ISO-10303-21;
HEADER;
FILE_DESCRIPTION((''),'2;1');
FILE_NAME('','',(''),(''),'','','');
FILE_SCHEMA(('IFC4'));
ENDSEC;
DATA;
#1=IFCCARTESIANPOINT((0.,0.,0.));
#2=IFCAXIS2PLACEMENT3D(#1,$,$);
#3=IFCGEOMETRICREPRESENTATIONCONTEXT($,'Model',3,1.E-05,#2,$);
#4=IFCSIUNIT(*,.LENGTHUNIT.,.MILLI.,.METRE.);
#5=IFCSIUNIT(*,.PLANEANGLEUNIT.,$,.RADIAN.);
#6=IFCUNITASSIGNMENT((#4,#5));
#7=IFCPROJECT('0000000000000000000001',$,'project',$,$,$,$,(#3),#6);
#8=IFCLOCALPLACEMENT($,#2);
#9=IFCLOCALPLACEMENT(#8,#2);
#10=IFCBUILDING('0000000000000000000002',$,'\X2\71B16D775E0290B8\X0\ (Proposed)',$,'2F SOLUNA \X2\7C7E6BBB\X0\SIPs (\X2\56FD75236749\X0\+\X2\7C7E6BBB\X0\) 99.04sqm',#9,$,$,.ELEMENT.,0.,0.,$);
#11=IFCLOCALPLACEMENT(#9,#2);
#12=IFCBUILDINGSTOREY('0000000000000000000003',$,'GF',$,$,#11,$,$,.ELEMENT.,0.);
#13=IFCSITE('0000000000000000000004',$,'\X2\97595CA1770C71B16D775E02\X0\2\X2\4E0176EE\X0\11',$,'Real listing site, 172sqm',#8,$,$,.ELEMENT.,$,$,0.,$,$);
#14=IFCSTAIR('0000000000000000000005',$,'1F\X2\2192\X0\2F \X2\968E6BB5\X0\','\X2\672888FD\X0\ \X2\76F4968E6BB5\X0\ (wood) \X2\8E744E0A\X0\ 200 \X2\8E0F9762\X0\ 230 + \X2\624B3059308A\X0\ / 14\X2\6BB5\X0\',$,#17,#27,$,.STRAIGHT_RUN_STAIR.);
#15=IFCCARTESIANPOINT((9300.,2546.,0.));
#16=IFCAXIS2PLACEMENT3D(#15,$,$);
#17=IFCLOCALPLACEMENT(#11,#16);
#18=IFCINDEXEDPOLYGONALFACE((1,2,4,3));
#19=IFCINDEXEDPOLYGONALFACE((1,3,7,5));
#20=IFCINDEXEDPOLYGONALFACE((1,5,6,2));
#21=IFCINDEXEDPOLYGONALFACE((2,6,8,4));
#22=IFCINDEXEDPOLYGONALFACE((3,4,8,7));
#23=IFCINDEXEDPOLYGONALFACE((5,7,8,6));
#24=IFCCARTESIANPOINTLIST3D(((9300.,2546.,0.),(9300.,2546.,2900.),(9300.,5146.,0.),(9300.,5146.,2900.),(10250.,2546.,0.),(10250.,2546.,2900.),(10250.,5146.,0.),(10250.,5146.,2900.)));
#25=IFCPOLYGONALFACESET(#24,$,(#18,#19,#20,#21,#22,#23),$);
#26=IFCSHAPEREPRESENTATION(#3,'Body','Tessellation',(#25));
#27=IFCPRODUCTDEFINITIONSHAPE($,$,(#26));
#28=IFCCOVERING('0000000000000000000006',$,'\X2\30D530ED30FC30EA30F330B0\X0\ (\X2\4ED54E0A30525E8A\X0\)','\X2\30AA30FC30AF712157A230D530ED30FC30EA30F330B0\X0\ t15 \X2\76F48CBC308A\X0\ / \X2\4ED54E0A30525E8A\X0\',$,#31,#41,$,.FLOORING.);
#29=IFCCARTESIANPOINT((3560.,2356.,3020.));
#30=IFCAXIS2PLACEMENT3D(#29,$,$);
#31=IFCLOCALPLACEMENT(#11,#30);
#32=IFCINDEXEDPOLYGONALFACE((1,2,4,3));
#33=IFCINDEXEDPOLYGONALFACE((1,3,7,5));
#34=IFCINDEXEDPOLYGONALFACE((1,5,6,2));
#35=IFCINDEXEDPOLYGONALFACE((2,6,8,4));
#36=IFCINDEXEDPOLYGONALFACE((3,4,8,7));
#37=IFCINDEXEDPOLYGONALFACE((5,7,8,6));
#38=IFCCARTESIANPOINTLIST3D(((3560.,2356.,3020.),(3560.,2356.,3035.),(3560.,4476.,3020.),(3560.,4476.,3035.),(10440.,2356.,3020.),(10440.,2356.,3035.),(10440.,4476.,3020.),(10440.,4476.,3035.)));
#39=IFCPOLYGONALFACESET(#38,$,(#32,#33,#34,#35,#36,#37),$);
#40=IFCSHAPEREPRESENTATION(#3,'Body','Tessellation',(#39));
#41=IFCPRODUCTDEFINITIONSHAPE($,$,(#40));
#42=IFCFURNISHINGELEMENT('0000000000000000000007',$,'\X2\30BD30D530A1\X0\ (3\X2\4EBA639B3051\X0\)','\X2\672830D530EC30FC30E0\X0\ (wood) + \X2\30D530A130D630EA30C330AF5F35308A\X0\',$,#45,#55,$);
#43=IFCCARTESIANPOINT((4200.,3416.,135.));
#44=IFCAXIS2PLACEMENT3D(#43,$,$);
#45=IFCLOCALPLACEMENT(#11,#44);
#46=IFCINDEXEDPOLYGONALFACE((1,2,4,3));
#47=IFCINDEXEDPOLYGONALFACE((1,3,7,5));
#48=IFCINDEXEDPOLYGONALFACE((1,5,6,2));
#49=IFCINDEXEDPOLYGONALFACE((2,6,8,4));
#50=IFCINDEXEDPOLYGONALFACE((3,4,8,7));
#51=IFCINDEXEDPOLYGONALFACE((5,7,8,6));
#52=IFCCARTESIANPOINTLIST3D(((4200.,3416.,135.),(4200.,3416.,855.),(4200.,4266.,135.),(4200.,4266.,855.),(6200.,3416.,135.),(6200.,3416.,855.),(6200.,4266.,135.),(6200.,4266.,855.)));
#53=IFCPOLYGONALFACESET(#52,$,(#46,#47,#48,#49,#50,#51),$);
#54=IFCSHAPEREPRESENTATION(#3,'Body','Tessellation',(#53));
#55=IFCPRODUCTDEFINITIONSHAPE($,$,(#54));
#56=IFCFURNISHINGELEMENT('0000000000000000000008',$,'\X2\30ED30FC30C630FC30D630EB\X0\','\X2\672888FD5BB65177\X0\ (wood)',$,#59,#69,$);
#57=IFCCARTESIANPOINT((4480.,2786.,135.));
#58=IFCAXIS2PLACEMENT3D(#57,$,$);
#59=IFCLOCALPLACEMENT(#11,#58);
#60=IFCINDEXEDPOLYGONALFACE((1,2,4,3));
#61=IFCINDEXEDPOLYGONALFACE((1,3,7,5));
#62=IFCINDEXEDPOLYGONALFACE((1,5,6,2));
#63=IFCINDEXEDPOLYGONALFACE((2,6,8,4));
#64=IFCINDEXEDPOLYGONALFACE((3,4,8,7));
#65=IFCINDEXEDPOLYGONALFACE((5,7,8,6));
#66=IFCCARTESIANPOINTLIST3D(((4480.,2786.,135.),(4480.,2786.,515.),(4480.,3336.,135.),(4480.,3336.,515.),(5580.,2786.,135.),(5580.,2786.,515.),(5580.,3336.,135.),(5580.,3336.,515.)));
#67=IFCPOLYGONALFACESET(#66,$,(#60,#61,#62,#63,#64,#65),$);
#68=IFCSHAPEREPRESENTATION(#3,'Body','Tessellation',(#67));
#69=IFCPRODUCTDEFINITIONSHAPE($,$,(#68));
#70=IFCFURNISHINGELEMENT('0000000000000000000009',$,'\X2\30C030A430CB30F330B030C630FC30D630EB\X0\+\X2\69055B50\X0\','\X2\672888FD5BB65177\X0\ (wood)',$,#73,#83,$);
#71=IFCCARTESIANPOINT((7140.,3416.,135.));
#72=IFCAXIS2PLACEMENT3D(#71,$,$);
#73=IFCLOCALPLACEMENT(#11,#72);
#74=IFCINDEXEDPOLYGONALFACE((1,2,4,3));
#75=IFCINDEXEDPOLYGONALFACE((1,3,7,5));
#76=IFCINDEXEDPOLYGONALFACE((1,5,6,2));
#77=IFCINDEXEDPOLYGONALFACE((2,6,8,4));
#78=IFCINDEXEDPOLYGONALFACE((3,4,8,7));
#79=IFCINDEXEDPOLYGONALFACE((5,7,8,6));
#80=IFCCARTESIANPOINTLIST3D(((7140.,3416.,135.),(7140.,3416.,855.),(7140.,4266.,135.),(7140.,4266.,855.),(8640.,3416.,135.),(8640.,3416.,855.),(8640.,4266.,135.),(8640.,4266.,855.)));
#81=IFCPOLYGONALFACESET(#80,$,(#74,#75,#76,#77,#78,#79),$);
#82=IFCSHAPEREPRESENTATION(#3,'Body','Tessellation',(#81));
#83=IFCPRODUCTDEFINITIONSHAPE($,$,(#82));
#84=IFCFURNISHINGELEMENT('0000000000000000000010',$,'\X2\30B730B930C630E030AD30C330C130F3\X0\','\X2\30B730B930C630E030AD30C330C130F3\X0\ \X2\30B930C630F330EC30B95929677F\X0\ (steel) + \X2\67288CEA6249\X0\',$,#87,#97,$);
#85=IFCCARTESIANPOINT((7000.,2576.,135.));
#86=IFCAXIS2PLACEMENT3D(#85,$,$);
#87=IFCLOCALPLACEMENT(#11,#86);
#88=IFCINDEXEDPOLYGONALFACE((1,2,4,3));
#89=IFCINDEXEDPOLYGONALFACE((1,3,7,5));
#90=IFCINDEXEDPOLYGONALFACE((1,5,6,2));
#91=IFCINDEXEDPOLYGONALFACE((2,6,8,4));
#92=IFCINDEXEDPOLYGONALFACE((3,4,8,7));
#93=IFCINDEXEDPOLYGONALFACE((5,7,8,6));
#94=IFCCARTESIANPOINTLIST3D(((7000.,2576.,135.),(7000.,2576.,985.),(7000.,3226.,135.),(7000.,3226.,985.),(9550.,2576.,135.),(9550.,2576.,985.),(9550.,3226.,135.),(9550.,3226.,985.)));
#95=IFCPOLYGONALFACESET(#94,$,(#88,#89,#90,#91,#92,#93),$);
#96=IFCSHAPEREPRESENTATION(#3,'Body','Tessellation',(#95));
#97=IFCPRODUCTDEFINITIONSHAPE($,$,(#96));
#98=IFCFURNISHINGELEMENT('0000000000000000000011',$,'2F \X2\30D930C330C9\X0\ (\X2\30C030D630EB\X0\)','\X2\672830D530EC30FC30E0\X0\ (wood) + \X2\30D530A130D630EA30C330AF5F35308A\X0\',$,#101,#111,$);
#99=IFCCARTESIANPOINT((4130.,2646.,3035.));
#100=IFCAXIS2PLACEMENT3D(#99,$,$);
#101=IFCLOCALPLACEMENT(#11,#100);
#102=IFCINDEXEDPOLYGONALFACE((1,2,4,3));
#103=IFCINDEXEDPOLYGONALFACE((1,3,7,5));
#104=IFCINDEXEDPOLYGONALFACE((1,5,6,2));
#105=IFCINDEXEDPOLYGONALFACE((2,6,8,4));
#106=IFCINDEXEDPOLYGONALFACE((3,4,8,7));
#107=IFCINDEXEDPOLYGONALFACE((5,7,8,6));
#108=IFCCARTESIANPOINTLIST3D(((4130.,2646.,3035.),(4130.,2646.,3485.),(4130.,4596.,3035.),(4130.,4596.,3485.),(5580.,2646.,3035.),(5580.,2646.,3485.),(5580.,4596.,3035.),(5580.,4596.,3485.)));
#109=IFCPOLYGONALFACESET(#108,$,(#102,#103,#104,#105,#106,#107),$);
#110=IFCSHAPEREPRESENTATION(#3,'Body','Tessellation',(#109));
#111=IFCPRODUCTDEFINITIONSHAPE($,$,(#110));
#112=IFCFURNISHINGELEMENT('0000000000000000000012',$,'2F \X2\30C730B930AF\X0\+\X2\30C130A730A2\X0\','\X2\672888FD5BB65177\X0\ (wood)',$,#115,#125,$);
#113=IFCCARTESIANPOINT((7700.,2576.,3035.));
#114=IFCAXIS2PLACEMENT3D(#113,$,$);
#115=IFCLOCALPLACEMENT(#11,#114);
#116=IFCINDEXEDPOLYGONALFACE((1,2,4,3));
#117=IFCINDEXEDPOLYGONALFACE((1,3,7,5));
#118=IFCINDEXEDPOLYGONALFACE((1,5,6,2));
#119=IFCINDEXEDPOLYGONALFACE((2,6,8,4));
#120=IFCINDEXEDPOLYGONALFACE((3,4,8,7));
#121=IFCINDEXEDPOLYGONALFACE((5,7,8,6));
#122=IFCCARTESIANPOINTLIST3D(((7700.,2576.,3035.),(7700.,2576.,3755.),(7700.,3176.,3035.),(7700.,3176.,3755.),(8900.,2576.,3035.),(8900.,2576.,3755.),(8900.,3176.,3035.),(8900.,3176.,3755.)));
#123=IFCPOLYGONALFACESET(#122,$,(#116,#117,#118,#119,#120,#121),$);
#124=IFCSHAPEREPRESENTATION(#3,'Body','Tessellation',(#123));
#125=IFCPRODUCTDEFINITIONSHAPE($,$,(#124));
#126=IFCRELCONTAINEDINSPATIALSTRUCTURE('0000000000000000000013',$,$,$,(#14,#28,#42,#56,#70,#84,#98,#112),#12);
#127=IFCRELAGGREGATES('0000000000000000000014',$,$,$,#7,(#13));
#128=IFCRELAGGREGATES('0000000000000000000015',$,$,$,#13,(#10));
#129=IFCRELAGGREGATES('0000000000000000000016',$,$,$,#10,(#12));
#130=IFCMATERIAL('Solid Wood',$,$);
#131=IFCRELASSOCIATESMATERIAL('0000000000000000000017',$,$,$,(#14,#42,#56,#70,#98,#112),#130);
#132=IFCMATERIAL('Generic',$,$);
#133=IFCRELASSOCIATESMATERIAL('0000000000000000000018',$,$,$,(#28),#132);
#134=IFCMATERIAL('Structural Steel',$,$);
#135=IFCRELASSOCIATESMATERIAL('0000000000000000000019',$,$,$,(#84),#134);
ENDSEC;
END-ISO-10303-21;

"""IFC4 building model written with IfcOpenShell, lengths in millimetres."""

from ifc_helpers import new_model, si_unit, frame, frame_2d, origin, place, context, project, spatial, rectangle, extrude, material, element, save


model = new_model("IFC4")

# Units and contexts
model_context = context("Model", 3, precision=1e-05, world=origin())
ifc_project = project(units=[si_unit("LENGTHUNIT", "METRE", prefix="MILLI"), si_unit("PLANEANGLEUNIT", "RADIAN")], contexts=[model_context])

# Site, building, storey
site_placement = place(None, origin())
site = spatial("IfcSite", under=ifc_project, at=site_placement, Name="静岡県熱海市2丁目11", ObjectType="Real listing site, 172sqm", CompositionType="ELEMENT", RefElevation=0.0)
building_placement = place(site_placement, origin())
building = spatial("IfcBuilding", under=site, at=building_placement, Name="熱海市邸 (Proposed)", ObjectType="2F SOLUNA 籾殻SIPs (国産杉+籾殻) 99.04sqm", CompositionType="ELEMENT", ElevationOfRefHeight=0.0, ElevationOfTerrain=0.0)
storey_placement = place(building_placement, origin())
storey = spatial("IfcBuildingStorey", under=building, at=storey_placement, Name="GF", CompositionType="ELEMENT", Elevation=0.0)

# Shared definitions
ifc_material_1 = material(Name="Solid Wood")

# Shared definitions
ifc_material_2 = material(Name="Generic")

# Stair
stair_placement = place(storey_placement, frame((9300.0, 2546.0, 0.0)))
element("IfcStair", 1, at=stair_placement, inside=storey, material=ifc_material_1, Name="1F→2F 階段", Description="木製 直階段 (wood) 蹴上 200 踏面 230 + 手すり / 14段", PredefinedType="STRAIGHT_RUN_STAIR", context=model_context, shape_type="SweptSolid", body=[
    extrude(rectangle(XDim=950.0, YDim=2600.0, at=frame_2d((475.0, 1300.0))), frame((9300.0, 2546.0, 0.0)), (0.0, 0.0, 1.0), 2900.0),
])

# Covering
covering_placement = place(storey_placement, frame((3560.0, 2356.0, 3020.0)))
element("IfcCovering", 2, at=covering_placement, inside=storey, material=ifc_material_2, Name="フローリング (仕上げ床)", Description="オーク無垢フローリング t15 直貼り / 仕上げ床", PredefinedType="FLOORING", context=model_context, shape_type="SweptSolid", body=[
    extrude(rectangle(XDim=6880.0, YDim=2120.0, at=frame_2d((3440.0, 1060.0))), frame((3560.0, 2356.0, 3020.0)), (0.0, 0.0, 1.0), 15.0),
])

# Furnishing elements
furnishing_1_placement = place(storey_placement, frame((4200.0, 3416.0, 135.0)))
element("IfcFurnishingElement", 3, at=furnishing_1_placement, inside=storey, material=ifc_material_1, Name="ソファ (3人掛け)", Description="木フレーム (wood) + ファブリック張り", context=model_context, shape_type="SweptSolid", body=[
    extrude(rectangle(XDim=2000.0, YDim=850.0, at=frame_2d((1000.0, 425.0))), frame((4200.0, 3416.0, 135.0)), (0.0, 0.0, 1.0), 720.0),
])
furnishing_2_placement = place(storey_placement, frame((4480.0, 2786.0, 135.0)))
element("IfcFurnishingElement", 4, at=furnishing_2_placement, inside=storey, material=ifc_material_1, Name="ローテーブル", Description="木製家具 (wood)", context=model_context, shape_type="SweptSolid", body=[
    extrude(rectangle(XDim=1100.0, YDim=550.0, at=frame_2d((550.0, 275.0))), frame((4480.0, 2786.0, 135.0)), (0.0, 0.0, 1.0), 380.0),
])
furnishing_3_placement = place(storey_placement, frame((7140.0, 3416.0, 135.0)))
element("IfcFurnishingElement", 5, at=furnishing_3_placement, inside=storey, material=ifc_material_1, Name="ダイニングテーブル+椅子", Description="木製家具 (wood)", context=model_context, shape_type="SweptSolid", body=[
    extrude(rectangle(XDim=1500.0, YDim=850.0, at=frame_2d((750.0, 425.0))), frame((7140.0, 3416.0, 135.0)), (0.0, 0.0, 1.0), 720.0),
])
ifc_material_3 = material(Name="Structural Steel")
furnishing_4_placement = place(storey_placement, frame((7000.0, 2576.0, 135.0)))
element("IfcFurnishingElement", 6, at=furnishing_4_placement, inside=storey, material=ifc_material_3, Name="システムキッチン", Description="システムキッチン ステンレス天板 (steel) + 木質扉", context=model_context, shape_type="SweptSolid", body=[
    extrude(rectangle(XDim=2550.0, YDim=650.0, at=frame_2d((1275.0, 325.0))), frame((7000.0, 2576.0, 135.0)), (0.0, 0.0, 1.0), 850.0),
])
furnishing_5_placement = place(storey_placement, frame((4130.0, 2646.0, 3035.0)))
element("IfcFurnishingElement", 7, at=furnishing_5_placement, inside=storey, material=ifc_material_1, Name="2F ベッド (ダブル)", Description="木フレーム (wood) + ファブリック張り", context=model_context, shape_type="SweptSolid", body=[
    extrude(rectangle(XDim=1450.0, YDim=1950.0, at=frame_2d((725.0, 975.0))), frame((4130.0, 2646.0, 3035.0)), (0.0, 0.0, 1.0), 450.0),
])
furnishing_6_placement = place(storey_placement, frame((7700.0, 2576.0, 3035.0)))
element("IfcFurnishingElement", 8, at=furnishing_6_placement, inside=storey, material=ifc_material_1, Name="2F デスク+チェア", Description="木製家具 (wood)", context=model_context, shape_type="SweptSolid", body=[
    extrude(rectangle(XDim=1200.0, YDim=600.0, at=frame_2d((600.0, 300.0))), frame((7700.0, 2576.0, 3035.0)), (0.0, 0.0, 1.0), 720.0),
])

save(model, "model.ifc")
